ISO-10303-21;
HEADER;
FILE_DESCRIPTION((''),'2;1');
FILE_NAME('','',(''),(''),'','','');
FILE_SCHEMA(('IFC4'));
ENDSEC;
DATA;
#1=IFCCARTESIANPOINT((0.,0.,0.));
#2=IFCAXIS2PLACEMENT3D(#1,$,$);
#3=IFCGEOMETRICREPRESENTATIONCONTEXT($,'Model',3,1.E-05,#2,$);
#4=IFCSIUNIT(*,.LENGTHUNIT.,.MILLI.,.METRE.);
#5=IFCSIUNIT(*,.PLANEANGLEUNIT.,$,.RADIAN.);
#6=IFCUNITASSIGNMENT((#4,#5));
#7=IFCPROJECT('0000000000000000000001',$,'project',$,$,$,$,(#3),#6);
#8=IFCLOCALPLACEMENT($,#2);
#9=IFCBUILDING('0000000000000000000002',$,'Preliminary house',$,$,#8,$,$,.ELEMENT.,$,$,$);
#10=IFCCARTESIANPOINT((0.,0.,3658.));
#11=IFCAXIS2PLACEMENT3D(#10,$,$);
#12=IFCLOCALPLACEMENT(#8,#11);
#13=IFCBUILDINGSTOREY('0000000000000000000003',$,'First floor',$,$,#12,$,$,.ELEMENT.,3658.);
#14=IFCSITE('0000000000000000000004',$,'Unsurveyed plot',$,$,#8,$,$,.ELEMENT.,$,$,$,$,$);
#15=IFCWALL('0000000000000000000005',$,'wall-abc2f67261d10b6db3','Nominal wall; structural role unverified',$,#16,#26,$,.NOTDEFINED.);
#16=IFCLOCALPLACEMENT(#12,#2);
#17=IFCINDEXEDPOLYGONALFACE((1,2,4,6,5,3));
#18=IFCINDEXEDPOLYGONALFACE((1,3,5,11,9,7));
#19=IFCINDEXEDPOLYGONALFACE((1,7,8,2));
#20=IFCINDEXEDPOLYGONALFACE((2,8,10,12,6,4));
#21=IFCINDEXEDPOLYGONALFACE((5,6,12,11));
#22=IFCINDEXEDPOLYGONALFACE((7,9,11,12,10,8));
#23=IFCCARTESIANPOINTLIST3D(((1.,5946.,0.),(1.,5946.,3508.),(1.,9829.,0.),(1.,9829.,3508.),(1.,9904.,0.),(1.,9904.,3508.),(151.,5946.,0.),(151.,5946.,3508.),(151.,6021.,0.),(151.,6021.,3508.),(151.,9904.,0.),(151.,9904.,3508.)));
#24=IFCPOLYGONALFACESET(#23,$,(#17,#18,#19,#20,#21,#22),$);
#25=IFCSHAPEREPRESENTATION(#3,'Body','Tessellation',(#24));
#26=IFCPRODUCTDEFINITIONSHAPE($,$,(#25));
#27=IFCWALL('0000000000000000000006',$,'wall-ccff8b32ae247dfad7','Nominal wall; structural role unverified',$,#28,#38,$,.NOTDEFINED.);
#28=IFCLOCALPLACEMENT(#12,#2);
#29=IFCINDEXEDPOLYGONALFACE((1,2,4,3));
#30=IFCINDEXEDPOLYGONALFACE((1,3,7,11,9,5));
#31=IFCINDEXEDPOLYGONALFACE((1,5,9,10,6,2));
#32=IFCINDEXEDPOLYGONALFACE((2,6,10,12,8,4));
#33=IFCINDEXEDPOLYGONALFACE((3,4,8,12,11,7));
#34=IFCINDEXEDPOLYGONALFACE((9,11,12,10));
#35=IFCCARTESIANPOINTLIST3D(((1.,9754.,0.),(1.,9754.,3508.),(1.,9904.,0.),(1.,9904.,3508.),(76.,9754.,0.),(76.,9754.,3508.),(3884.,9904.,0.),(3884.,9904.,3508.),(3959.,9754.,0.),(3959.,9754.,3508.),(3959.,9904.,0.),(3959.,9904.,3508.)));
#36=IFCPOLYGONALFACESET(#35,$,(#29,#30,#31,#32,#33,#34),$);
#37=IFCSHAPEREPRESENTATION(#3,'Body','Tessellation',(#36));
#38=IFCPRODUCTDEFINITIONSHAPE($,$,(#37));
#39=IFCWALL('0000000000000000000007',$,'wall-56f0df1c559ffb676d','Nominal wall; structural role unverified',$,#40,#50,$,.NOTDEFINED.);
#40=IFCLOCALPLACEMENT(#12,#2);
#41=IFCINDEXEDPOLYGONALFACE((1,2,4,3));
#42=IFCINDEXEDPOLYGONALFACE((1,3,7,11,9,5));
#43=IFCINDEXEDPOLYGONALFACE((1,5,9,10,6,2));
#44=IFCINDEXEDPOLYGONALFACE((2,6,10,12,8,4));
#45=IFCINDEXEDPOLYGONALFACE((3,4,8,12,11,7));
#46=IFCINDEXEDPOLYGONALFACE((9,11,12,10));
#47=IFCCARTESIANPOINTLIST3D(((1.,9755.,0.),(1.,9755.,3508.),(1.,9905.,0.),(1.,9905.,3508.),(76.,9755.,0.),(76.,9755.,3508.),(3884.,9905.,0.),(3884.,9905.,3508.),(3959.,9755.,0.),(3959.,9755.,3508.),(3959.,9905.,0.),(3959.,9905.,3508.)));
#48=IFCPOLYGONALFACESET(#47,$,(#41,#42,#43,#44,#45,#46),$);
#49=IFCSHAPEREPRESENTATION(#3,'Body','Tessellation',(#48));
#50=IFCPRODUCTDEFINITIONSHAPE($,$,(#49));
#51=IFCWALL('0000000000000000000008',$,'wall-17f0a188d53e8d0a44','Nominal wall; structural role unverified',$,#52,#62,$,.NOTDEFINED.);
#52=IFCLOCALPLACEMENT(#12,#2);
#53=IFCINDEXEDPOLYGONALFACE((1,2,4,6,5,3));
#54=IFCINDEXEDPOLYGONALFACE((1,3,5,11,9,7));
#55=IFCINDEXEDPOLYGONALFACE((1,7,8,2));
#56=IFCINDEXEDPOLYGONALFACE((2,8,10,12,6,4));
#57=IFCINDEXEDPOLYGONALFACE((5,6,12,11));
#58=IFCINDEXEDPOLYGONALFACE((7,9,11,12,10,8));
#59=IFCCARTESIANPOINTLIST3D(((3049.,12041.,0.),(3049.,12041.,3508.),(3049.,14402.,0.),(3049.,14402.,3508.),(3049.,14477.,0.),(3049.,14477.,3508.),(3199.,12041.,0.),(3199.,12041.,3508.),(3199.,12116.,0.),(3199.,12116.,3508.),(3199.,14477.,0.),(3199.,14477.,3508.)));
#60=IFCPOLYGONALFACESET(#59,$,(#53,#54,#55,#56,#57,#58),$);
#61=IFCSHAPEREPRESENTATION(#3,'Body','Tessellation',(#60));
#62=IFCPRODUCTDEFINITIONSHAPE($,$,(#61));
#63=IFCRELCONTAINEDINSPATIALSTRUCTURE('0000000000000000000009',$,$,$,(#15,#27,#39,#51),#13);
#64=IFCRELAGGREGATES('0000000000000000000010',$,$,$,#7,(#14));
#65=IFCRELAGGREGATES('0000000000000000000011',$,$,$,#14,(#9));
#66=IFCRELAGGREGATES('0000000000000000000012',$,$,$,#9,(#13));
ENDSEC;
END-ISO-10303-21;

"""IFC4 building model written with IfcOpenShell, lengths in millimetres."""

from ifc_helpers import new_model, si_unit, frame, origin, place, context, project, spatial, polyline, outline, extrude, element, save


model = new_model("IFC4")

# Units and contexts
model_context = context("Model", 3, precision=1e-05, world=origin())
ifc_project = project(units=[si_unit("LENGTHUNIT", "METRE", prefix="MILLI"), si_unit("PLANEANGLEUNIT", "RADIAN")], contexts=[model_context])

# Site, building, storey
placement_1 = place(None, origin())
site = spatial("IfcSite", under=ifc_project, at=placement_1, Name="Unsurveyed plot", CompositionType="ELEMENT")
building = spatial("IfcBuilding", under=site, at=placement_1, Name="Preliminary house", CompositionType="ELEMENT")
placement_2 = place(placement_1, frame((0.0, 0.0, 3658.0)))
storey = spatial("IfcBuildingStorey", under=building, at=placement_2, Name="First floor", CompositionType="ELEMENT", Elevation=3658.0)

# Wall
element("IfcWall", 1, at=placement_2, inside=storey, Name="wall-abc2f67261d10b6db3", Description="Nominal wall; structural role unverified", PredefinedType="NOTDEFINED", context=model_context, shape_type="SweptSolid", body=[
    extrude(outline(polyline([(1.0, 9829.0), (1.0, 9904.0), (151.0, 9904.0), (151.0, 6021.0), (151.0, 5946.0), (1.0, 5946.0), (1.0, 9829.0)])), origin(), (0.0, 0.0, 1.0), 3508.0),
])

# Wall
element("IfcWall", 2, at=placement_2, inside=storey, Name="wall-ccff8b32ae247dfad7", Description="Nominal wall; structural role unverified", PredefinedType="NOTDEFINED", context=model_context, shape_type="SweptSolid", body=[
    extrude(outline(polyline([(3884.0, 9904.0), (3959.0, 9904.0), (3959.0, 9754.0), (76.0, 9754.0), (1.0, 9754.0), (1.0, 9904.0), (3884.0, 9904.0)])), origin(), (0.0, 0.0, 1.0), 3508.0),
])

# Wall
element("IfcWall", 3, at=placement_2, inside=storey, Name="wall-56f0df1c559ffb676d", Description="Nominal wall; structural role unverified", PredefinedType="NOTDEFINED", context=model_context, shape_type="SweptSolid", body=[
    extrude(outline(polyline([(3884.0, 9905.0), (3959.0, 9905.0), (3959.0, 9755.0), (76.0, 9755.0), (1.0, 9755.0), (1.0, 9905.0), (3884.0, 9905.0)])), origin(), (0.0, 0.0, 1.0), 3508.0),
])

# Wall
element("IfcWall", 4, at=placement_2, inside=storey, Name="wall-17f0a188d53e8d0a44", Description="Nominal wall; structural role unverified", PredefinedType="NOTDEFINED", context=model_context, shape_type="SweptSolid", body=[
    extrude(outline(polyline([(3049.0, 14402.0), (3049.0, 14477.0), (3199.0, 14477.0), (3199.0, 12116.0), (3199.0, 12041.0), (3049.0, 12041.0), (3049.0, 14402.0)])), origin(), (0.0, 0.0, 1.0), 3508.0),
])

save(model, "model.ifc")
